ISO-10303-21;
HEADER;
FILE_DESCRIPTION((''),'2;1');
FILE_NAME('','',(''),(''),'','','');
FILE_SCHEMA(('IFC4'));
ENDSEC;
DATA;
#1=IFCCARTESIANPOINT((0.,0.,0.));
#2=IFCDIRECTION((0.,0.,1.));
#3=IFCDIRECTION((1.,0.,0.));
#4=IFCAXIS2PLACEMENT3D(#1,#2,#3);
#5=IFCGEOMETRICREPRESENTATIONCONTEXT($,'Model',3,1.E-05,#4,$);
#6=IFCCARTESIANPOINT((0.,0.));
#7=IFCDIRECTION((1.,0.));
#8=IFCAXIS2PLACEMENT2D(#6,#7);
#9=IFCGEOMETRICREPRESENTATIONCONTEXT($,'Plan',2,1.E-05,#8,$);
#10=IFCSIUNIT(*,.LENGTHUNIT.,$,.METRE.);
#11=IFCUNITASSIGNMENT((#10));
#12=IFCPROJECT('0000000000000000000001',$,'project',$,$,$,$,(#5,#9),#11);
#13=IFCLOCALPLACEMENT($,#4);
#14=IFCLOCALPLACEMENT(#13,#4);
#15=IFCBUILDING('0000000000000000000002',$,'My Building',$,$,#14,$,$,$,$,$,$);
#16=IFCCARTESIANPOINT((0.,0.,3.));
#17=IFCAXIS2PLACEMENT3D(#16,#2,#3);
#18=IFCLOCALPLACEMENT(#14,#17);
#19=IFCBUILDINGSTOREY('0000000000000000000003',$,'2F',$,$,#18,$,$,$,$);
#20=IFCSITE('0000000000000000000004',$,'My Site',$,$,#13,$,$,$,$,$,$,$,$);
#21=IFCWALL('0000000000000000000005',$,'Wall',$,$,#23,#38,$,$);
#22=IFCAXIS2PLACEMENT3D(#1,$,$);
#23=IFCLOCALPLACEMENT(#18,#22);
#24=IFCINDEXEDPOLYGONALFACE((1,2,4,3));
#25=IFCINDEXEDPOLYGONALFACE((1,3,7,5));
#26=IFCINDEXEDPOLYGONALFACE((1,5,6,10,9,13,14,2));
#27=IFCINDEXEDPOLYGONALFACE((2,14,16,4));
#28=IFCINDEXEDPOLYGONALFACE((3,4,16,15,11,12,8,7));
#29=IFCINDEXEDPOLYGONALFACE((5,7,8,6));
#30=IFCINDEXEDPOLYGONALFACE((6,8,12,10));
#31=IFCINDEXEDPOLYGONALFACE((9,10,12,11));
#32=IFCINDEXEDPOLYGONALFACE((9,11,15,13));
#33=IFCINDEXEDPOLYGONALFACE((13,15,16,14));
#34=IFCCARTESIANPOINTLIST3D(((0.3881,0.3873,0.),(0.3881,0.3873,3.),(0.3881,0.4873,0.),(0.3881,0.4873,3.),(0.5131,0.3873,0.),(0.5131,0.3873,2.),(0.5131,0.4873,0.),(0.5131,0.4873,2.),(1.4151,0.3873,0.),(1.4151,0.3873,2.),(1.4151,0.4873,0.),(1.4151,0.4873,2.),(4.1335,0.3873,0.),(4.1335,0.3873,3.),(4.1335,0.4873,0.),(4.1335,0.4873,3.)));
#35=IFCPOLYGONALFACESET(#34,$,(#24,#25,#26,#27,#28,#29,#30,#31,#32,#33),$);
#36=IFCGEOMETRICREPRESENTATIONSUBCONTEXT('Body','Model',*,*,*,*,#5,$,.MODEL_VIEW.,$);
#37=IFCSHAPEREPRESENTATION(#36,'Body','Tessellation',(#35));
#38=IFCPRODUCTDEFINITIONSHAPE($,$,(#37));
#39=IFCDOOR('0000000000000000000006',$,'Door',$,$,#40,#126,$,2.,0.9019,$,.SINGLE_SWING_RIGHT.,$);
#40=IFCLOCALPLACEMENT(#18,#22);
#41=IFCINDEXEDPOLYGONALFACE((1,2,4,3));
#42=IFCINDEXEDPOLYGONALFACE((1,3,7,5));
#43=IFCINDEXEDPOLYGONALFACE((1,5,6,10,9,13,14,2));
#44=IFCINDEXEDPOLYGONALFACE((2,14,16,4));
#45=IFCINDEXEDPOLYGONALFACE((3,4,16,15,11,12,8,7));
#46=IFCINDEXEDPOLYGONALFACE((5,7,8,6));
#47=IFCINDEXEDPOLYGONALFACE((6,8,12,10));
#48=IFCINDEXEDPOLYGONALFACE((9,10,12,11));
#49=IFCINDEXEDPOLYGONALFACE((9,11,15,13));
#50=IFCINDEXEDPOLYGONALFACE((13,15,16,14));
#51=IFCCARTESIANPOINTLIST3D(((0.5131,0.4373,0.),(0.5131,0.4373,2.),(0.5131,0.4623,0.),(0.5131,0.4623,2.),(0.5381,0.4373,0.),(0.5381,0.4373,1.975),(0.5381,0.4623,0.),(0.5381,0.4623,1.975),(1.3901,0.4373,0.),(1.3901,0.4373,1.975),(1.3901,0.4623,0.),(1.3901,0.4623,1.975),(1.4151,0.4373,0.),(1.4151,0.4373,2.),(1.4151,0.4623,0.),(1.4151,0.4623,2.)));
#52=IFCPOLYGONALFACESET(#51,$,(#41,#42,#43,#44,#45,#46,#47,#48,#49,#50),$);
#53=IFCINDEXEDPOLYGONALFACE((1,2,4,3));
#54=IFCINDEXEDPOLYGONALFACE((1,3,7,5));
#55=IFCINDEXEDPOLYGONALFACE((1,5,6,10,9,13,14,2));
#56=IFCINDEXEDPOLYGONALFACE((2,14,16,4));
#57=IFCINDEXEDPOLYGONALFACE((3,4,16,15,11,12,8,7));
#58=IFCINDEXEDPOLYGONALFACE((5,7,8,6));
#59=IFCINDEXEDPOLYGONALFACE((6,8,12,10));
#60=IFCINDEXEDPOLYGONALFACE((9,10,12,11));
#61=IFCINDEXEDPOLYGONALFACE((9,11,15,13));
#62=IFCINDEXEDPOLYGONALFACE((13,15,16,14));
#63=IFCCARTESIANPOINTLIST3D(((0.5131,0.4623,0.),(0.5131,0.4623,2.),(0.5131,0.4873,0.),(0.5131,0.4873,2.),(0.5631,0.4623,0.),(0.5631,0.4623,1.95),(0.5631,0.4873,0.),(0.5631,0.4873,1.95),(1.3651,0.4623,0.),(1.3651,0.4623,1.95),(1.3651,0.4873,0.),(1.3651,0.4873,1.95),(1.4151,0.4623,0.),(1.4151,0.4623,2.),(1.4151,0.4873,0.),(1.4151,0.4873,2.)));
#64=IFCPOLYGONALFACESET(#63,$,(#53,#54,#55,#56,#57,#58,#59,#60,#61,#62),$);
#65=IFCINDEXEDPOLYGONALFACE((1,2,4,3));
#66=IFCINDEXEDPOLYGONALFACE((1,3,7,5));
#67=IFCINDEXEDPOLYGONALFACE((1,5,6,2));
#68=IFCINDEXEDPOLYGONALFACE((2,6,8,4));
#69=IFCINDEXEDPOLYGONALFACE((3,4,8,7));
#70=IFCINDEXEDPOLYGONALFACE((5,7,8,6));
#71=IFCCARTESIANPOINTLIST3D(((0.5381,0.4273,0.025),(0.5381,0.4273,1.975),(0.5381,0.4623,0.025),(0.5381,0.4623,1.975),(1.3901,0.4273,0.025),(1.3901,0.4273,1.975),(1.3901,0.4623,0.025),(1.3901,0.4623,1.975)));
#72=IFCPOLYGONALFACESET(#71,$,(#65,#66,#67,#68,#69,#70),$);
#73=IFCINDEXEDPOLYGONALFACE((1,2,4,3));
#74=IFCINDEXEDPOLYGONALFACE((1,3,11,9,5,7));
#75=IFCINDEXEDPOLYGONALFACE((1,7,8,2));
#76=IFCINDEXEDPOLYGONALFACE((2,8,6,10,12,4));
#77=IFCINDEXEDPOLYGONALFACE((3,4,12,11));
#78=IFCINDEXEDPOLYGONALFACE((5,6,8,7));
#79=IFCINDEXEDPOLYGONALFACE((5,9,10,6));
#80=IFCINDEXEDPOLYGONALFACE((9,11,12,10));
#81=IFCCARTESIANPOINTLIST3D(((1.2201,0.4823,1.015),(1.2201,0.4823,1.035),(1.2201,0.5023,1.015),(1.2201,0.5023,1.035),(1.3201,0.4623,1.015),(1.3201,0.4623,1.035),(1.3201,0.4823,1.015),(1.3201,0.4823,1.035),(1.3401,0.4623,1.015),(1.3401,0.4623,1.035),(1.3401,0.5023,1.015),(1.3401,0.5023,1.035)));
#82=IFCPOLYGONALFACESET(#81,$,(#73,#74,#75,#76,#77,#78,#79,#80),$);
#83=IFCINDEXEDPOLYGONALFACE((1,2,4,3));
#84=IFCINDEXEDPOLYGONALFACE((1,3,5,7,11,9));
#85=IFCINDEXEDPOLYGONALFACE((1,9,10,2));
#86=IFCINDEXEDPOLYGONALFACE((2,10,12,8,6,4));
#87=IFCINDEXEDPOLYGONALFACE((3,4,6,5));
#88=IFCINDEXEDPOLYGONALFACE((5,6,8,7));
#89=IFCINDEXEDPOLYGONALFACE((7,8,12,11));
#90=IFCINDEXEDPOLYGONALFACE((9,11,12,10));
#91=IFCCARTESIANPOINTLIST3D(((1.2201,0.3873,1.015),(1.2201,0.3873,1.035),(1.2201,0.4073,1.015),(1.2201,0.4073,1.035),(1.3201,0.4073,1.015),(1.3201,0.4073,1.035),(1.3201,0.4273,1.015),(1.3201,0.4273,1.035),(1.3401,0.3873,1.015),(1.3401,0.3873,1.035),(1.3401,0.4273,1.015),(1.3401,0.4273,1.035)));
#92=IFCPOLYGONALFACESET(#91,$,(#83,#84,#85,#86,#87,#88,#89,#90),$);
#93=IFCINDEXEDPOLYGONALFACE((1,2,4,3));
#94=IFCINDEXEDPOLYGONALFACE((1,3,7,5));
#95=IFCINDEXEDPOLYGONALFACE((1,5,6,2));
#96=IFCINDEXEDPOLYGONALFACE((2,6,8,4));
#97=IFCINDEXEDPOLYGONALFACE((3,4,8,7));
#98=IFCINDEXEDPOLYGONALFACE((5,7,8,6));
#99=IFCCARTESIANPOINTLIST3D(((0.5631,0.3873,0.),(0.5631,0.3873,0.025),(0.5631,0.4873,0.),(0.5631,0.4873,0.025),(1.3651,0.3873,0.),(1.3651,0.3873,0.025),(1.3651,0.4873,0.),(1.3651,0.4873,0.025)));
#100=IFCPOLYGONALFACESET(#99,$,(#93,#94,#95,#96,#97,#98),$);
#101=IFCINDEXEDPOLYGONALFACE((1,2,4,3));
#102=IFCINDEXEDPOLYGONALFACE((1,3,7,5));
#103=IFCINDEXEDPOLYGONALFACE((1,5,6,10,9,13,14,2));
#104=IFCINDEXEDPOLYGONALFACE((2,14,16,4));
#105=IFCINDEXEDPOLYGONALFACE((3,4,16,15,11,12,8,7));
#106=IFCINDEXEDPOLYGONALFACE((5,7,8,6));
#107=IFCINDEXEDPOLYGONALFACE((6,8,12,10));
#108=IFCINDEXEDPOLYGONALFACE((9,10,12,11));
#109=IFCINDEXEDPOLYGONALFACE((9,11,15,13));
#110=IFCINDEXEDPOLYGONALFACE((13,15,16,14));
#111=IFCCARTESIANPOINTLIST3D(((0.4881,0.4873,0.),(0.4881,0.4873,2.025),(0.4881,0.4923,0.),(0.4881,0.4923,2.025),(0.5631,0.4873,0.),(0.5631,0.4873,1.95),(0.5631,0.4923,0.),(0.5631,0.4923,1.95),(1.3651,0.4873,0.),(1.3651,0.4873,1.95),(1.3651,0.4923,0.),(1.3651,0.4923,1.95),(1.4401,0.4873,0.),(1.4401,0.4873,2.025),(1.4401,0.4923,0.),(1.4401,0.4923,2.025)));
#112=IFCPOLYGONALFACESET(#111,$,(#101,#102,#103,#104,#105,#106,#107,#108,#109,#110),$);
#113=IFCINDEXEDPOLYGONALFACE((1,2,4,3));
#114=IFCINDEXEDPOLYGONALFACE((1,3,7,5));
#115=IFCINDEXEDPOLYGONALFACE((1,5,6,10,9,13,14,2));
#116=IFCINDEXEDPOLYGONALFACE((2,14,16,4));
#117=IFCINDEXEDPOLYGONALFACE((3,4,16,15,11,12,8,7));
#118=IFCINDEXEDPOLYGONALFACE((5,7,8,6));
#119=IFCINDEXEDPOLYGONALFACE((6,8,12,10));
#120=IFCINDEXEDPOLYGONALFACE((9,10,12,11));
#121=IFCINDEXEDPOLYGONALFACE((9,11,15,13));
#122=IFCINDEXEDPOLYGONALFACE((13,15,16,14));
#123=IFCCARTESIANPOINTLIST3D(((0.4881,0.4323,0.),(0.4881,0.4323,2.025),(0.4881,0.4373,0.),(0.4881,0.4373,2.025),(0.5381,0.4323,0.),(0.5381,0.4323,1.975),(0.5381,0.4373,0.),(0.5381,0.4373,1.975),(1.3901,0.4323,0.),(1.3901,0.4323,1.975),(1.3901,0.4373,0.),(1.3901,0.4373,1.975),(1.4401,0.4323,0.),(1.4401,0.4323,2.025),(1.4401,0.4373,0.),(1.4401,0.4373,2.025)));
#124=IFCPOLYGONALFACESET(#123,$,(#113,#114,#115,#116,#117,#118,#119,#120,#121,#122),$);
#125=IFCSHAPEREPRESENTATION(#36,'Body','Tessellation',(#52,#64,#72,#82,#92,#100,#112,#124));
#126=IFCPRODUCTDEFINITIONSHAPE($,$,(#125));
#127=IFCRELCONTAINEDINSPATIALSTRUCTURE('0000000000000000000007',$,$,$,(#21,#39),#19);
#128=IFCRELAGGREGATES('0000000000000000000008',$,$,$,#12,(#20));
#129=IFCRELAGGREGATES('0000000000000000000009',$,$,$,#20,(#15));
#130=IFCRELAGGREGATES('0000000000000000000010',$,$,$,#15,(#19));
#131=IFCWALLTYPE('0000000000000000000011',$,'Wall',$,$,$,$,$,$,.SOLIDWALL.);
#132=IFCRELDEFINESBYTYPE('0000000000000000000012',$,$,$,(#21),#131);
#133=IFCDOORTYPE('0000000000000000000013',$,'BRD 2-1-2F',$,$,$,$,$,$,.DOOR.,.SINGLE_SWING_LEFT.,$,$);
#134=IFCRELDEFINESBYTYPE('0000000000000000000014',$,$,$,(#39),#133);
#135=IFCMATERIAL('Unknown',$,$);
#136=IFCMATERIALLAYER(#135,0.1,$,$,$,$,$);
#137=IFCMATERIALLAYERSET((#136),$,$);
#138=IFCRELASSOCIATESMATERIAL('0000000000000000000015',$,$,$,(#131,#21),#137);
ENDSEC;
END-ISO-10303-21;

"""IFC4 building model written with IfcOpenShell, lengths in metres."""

from ifc_helpers import new_model, entity, si_unit, frame, origin_with_axes, origin_2d_with_axis, place, context, subcontext, project, spatial, line, indexed_curve, outline, extrude, shape, source, transform, mapped, material, layer, layer_set, layer_usage, type_object, type_shapes, element, fill, save


model = new_model("IFC4")

# Units and contexts
model_context = context("Model", 3, precision=1e-05, world=origin_with_axes())
plan_context = context("Plan", 2, precision=1e-05, world=origin_2d_with_axis())
body_context_1 = subcontext(model_context, "Body", "Model", "MODEL_VIEW")
body_context_2 = subcontext(plan_context, "Body", "Plan", "PLAN_VIEW")
ifc_project = project(units=[si_unit("LENGTHUNIT", "METRE")], contexts=[model_context, plan_context])

# Site, building, storey
site_placement = place(None, origin_with_axes())
site = spatial("IfcSite", under=ifc_project, at=site_placement, Name="My Site")
building_placement = place(site_placement, origin_with_axes())
building = spatial("IfcBuilding", under=site, at=building_placement, Name="My Building")
storey_placement = place(building_placement, frame((0.0, 0.0, 3.0), z_axis=(0.0, 0.0, 1.0), x_axis=(1.0, 0.0, 0.0)))
storey = spatial("IfcBuildingStorey", under=building, at=storey_placement, Name="2F")

# Shared definitions
ifc_material = material(Name="Unknown")

# Shared definitions
ifc_layer_1 = layer(ifc_material, 0.1)
ifc_layer_set_1 = layer_set([ifc_layer_1])
wall_type = type_object("IfcWallType", Name="Wall", PredefinedType="SOLIDWALL", material=ifc_layer_set_1)

# Wall, opening, door
ifc_layer_usage_1 = layer_usage(ifc_layer_set_1, "AXIS2", "POSITIVE", 0.0)
wall_1_placement = place(storey_placement, frame((0.3881, 0.3873, 0.0), z_axis=(0.0, 0.0, 1.0), x_axis=(1.0, 0.0, 0.0)))
wall_1 = element("IfcWall", 1, at=wall_1_placement, inside=storey, type_object=wall_type, material=ifc_layer_usage_1, Name="Wall", context=body_context_1, shape_type="SweptSolid", body=[
    extrude(outline(indexed_curve([(0.0, 0.0), (0.0, 0.1), (3.7454, 0.1), (3.7454, 0.0)], segments=[line(1, 2, 3, 4, 1)])), origin_with_axes(), (0.0, 0.0, 1.0), 3.0),
])
shared_shape_1 = source(origin_with_axes(), body_context_1, "Body", "SweptSolid", [
    extrude(outline(indexed_curve([(0.0, 0.0), (0.9019, 0.0), (0.9019, 2.0), (0.0, 2.0)], segments=[line(1, 2, 3, 4, 1)])), frame((0.0, -0.6, 0.0), z_axis=(0.0, -1.0, 0.0), x_axis=(1.0, 0.0, 0.0)), (0.0, 0.0, -1.0), 1.2),
])
opening_1_placement = place(wall_1_placement, frame((1.0269, 0.1, 0.0), z_axis=(0.0, 0.0, 1.0), x_axis=(-1.0, 0.000001, 0.0)))
opening_1 = element("IfcOpeningElement", 2, at=opening_1_placement, cuts=wall_1, PredefinedType="OPENING", context=body_context_1, shape_type="MappedRepresentation", body=[
    mapped(shared_shape_1, transform((0.0, 0.0, 0.0), x_axis=(1.0, 0.0, 0.0), y_axis=(0.0, 1.0, 0.0), z_axis=(0.0, 0.0, 1.0), scale=1.0)),
])
door_type_1 = type_object("IfcDoorType", Name="BRD 2-1-2F", OperationType="SINGLE_SWING_LEFT", PredefinedType="DOOR")
shared_shape_2 = source(origin_with_axes(), body_context_1, "Body", "SweptSolid", [
    extrude(outline(indexed_curve([(0.0, 0.0), (0.0, 2.0), (0.9019, 2.0), (0.9019, 0.0), (0.8769, 0.0), (0.8769, 1.975), (0.025, 1.975), (0.025, 0.0)], segments=[line(1, 2, 3, 4, 5, 6, 7, 8, 1)])), frame((0.0, 0.025, 0.0), z_axis=(0.0, -1.0, 0.0), x_axis=(1.0, 0.0, 0.0)), (0.0, 0.0, -1.0), 0.025),
    extrude(outline(indexed_curve([(0.0, 0.0), (0.0, 2.0), (0.9019, 2.0), (0.9019, 0.0), (0.8519, 0.0), (0.8519, 1.95), (0.05, 1.95), (0.05, 0.0)], segments=[line(1, 2, 3, 4, 5, 6, 7, 8, 1)])), frame((0.0, 0.0, 0.0), z_axis=(0.0, -1.0, 0.0), x_axis=(1.0, 0.0, 0.0)), (0.0, 0.0, -1.0), 0.025),
    extrude(outline(indexed_curve([(0.0, 0.0), (0.8519, 0.0), (0.8519, 0.035), (0.0, 0.035)], segments=[line(1, 2, 3, 4, 1)])), frame((0.025, 0.025, 0.025), z_axis=(0.0, 0.0, 1.0), x_axis=(1.0, 0.0, 0.0)), (0.0, 0.0, 1.0), 1.95),
    extrude(outline(indexed_curve([(0.0, 0.0), (0.0, -0.04), (0.12, -0.04), (0.12, -0.02), (0.02, -0.02), (0.02, 0.0)], segments=[line(1, 2, 3, 4, 5, 6, 1)])), frame((0.075, 0.025, 1.015), z_axis=(0.0, 0.0, 1.0), x_axis=(1.0, 0.0, 0.0)), (0.0, 0.0, 1.0), 0.02),
    extrude(outline(indexed_curve([(0.0, 0.0), (0.0, 0.04), (0.12, 0.04), (0.12, 0.02), (0.02, 0.02), (0.02, 0.0)], segments=[line(1, 2, 3, 4, 5, 6, 1)])), frame((0.075, 0.06, 1.015), z_axis=(0.0, 0.0, 1.0), x_axis=(1.0, 0.0, 0.0)), (0.0, 0.0, 1.0), 0.02),
    extrude(outline(indexed_curve([(0.0, 0.0), (0.8019, 0.0), (0.8019, 0.1), (0.0, 0.1)], segments=[line(1, 2, 3, 4, 1)])), frame((0.05, 0.0, 0.0), z_axis=(0.0, 0.0, 1.0), x_axis=(1.0, 0.0, 0.0)), (0.0, 0.0, 1.0), 0.025),
    extrude(outline(indexed_curve([(0.0, 0.0), (0.0, 2.025), (0.9519, 2.025), (0.9519, 0.0), (0.8769, 0.0), (0.8769, 1.95), (0.075, 1.95), (0.075, 0.0)], segments=[line(1, 2, 3, 4, 5, 6, 7, 8, 1)])), frame((-0.025, -0.005, 0.0), z_axis=(0.0, -1.0, 0.0), x_axis=(1.0, 0.0, 0.0)), (0.0, 0.0, -1.0), 0.005),
    extrude(outline(indexed_curve([(0.0, 0.0), (0.0, 2.025), (0.9519, 2.025), (0.9519, 0.0), (0.9019, 0.0), (0.9019, 1.975), (0.05, 1.975), (0.05, 0.0)], segments=[line(1, 2, 3, 4, 5, 6, 7, 8, 1)])), frame((-0.025, 0.05, 0.0), z_axis=(0.0, -1.0, 0.0), x_axis=(1.0, 0.0, 0.0)), (0.0, 0.0, -1.0), 0.005),
])
shared_shape_3 = source(origin_with_axes(), body_context_2, "Body", "Curve2D", [
    entity("IfcIndexedPolyCurve", entity("IfcCartesianPointList2D", [[0.0, 0.0], [0.0, 0.05], [0.025, 0.05], [0.025, 0.025], [0.05, 0.025], [0.05, 0.0]]), [entity("IfcLineIndex", [1, 2, 3, 4, 5, 6, 1])]),
    entity("IfcIndexedPolyCurve", entity("IfcCartesianPointList2D", [[0.9019, 0.0], [0.9019, 0.05], [0.8769, 0.05], [0.8769, 0.025], [0.8519, 0.025], [0.8519, 0.0]]), [entity("IfcLineIndex", [1, 2, 3, 4, 5, 6, 1])]),
    entity("IfcTrimmedCurve", entity("IfcEllipse", entity("IfcAxis2Placement2D", entity("IfcCartesianPoint", [0.8419, 0.05]), entity("IfcDirection", [1.0, 0.0])), 0.8169, 0.8519), [entity("IfcCartesianPoint", [0.8419, 0.9019])], [entity("IfcCartesianPoint", [0.025, 0.05])], True, "CARTESIAN"),
    entity("IfcIndexedPolyCurve", entity("IfcCartesianPointList2D", [[0.8769, 0.05], [0.8419, 0.05], [0.8419, 0.9019], [0.8769, 0.9019]]), [entity("IfcLineIndex", [1, 2, 3, 4, 1])]),
])
type_shapes(door_type_1, [shared_shape_2, shared_shape_3])
door_1_placement = place(opening_1_placement, frame((0.0, 0.0, 0.0), z_axis=(0.0, 0.0, 1.0), x_axis=(1.0, 0.0, 0.0)))
door_1 = element("IfcDoor", 3, at=door_1_placement, inside=storey, type_object=door_type_1, Name="Door", OperationType="SINGLE_SWING_RIGHT", OverallHeight=2.0, OverallWidth=0.9019, shapes=[
    shape(body_context_1, "Body", "MappedRepresentation", [mapped(shared_shape_2, transform((0.0, 0.0, 0.0), x_axis=(1.0, 0.0, 0.0), y_axis=(0.0, 1.0, 0.0), z_axis=(0.0, 0.0, 1.0), scale=1.0))]),
    shape(body_context_2, "Body", "MappedRepresentation", [mapped(shared_shape_3, transform((0.0, 0.0, 0.0), x_axis=(1.0, 0.0, 0.0), y_axis=(0.0, 1.0, 0.0), z_axis=(0.0, 0.0, 1.0), scale=1.0))]),
])
fill(opening_1, door_1)

save(model, "model.ifc")
